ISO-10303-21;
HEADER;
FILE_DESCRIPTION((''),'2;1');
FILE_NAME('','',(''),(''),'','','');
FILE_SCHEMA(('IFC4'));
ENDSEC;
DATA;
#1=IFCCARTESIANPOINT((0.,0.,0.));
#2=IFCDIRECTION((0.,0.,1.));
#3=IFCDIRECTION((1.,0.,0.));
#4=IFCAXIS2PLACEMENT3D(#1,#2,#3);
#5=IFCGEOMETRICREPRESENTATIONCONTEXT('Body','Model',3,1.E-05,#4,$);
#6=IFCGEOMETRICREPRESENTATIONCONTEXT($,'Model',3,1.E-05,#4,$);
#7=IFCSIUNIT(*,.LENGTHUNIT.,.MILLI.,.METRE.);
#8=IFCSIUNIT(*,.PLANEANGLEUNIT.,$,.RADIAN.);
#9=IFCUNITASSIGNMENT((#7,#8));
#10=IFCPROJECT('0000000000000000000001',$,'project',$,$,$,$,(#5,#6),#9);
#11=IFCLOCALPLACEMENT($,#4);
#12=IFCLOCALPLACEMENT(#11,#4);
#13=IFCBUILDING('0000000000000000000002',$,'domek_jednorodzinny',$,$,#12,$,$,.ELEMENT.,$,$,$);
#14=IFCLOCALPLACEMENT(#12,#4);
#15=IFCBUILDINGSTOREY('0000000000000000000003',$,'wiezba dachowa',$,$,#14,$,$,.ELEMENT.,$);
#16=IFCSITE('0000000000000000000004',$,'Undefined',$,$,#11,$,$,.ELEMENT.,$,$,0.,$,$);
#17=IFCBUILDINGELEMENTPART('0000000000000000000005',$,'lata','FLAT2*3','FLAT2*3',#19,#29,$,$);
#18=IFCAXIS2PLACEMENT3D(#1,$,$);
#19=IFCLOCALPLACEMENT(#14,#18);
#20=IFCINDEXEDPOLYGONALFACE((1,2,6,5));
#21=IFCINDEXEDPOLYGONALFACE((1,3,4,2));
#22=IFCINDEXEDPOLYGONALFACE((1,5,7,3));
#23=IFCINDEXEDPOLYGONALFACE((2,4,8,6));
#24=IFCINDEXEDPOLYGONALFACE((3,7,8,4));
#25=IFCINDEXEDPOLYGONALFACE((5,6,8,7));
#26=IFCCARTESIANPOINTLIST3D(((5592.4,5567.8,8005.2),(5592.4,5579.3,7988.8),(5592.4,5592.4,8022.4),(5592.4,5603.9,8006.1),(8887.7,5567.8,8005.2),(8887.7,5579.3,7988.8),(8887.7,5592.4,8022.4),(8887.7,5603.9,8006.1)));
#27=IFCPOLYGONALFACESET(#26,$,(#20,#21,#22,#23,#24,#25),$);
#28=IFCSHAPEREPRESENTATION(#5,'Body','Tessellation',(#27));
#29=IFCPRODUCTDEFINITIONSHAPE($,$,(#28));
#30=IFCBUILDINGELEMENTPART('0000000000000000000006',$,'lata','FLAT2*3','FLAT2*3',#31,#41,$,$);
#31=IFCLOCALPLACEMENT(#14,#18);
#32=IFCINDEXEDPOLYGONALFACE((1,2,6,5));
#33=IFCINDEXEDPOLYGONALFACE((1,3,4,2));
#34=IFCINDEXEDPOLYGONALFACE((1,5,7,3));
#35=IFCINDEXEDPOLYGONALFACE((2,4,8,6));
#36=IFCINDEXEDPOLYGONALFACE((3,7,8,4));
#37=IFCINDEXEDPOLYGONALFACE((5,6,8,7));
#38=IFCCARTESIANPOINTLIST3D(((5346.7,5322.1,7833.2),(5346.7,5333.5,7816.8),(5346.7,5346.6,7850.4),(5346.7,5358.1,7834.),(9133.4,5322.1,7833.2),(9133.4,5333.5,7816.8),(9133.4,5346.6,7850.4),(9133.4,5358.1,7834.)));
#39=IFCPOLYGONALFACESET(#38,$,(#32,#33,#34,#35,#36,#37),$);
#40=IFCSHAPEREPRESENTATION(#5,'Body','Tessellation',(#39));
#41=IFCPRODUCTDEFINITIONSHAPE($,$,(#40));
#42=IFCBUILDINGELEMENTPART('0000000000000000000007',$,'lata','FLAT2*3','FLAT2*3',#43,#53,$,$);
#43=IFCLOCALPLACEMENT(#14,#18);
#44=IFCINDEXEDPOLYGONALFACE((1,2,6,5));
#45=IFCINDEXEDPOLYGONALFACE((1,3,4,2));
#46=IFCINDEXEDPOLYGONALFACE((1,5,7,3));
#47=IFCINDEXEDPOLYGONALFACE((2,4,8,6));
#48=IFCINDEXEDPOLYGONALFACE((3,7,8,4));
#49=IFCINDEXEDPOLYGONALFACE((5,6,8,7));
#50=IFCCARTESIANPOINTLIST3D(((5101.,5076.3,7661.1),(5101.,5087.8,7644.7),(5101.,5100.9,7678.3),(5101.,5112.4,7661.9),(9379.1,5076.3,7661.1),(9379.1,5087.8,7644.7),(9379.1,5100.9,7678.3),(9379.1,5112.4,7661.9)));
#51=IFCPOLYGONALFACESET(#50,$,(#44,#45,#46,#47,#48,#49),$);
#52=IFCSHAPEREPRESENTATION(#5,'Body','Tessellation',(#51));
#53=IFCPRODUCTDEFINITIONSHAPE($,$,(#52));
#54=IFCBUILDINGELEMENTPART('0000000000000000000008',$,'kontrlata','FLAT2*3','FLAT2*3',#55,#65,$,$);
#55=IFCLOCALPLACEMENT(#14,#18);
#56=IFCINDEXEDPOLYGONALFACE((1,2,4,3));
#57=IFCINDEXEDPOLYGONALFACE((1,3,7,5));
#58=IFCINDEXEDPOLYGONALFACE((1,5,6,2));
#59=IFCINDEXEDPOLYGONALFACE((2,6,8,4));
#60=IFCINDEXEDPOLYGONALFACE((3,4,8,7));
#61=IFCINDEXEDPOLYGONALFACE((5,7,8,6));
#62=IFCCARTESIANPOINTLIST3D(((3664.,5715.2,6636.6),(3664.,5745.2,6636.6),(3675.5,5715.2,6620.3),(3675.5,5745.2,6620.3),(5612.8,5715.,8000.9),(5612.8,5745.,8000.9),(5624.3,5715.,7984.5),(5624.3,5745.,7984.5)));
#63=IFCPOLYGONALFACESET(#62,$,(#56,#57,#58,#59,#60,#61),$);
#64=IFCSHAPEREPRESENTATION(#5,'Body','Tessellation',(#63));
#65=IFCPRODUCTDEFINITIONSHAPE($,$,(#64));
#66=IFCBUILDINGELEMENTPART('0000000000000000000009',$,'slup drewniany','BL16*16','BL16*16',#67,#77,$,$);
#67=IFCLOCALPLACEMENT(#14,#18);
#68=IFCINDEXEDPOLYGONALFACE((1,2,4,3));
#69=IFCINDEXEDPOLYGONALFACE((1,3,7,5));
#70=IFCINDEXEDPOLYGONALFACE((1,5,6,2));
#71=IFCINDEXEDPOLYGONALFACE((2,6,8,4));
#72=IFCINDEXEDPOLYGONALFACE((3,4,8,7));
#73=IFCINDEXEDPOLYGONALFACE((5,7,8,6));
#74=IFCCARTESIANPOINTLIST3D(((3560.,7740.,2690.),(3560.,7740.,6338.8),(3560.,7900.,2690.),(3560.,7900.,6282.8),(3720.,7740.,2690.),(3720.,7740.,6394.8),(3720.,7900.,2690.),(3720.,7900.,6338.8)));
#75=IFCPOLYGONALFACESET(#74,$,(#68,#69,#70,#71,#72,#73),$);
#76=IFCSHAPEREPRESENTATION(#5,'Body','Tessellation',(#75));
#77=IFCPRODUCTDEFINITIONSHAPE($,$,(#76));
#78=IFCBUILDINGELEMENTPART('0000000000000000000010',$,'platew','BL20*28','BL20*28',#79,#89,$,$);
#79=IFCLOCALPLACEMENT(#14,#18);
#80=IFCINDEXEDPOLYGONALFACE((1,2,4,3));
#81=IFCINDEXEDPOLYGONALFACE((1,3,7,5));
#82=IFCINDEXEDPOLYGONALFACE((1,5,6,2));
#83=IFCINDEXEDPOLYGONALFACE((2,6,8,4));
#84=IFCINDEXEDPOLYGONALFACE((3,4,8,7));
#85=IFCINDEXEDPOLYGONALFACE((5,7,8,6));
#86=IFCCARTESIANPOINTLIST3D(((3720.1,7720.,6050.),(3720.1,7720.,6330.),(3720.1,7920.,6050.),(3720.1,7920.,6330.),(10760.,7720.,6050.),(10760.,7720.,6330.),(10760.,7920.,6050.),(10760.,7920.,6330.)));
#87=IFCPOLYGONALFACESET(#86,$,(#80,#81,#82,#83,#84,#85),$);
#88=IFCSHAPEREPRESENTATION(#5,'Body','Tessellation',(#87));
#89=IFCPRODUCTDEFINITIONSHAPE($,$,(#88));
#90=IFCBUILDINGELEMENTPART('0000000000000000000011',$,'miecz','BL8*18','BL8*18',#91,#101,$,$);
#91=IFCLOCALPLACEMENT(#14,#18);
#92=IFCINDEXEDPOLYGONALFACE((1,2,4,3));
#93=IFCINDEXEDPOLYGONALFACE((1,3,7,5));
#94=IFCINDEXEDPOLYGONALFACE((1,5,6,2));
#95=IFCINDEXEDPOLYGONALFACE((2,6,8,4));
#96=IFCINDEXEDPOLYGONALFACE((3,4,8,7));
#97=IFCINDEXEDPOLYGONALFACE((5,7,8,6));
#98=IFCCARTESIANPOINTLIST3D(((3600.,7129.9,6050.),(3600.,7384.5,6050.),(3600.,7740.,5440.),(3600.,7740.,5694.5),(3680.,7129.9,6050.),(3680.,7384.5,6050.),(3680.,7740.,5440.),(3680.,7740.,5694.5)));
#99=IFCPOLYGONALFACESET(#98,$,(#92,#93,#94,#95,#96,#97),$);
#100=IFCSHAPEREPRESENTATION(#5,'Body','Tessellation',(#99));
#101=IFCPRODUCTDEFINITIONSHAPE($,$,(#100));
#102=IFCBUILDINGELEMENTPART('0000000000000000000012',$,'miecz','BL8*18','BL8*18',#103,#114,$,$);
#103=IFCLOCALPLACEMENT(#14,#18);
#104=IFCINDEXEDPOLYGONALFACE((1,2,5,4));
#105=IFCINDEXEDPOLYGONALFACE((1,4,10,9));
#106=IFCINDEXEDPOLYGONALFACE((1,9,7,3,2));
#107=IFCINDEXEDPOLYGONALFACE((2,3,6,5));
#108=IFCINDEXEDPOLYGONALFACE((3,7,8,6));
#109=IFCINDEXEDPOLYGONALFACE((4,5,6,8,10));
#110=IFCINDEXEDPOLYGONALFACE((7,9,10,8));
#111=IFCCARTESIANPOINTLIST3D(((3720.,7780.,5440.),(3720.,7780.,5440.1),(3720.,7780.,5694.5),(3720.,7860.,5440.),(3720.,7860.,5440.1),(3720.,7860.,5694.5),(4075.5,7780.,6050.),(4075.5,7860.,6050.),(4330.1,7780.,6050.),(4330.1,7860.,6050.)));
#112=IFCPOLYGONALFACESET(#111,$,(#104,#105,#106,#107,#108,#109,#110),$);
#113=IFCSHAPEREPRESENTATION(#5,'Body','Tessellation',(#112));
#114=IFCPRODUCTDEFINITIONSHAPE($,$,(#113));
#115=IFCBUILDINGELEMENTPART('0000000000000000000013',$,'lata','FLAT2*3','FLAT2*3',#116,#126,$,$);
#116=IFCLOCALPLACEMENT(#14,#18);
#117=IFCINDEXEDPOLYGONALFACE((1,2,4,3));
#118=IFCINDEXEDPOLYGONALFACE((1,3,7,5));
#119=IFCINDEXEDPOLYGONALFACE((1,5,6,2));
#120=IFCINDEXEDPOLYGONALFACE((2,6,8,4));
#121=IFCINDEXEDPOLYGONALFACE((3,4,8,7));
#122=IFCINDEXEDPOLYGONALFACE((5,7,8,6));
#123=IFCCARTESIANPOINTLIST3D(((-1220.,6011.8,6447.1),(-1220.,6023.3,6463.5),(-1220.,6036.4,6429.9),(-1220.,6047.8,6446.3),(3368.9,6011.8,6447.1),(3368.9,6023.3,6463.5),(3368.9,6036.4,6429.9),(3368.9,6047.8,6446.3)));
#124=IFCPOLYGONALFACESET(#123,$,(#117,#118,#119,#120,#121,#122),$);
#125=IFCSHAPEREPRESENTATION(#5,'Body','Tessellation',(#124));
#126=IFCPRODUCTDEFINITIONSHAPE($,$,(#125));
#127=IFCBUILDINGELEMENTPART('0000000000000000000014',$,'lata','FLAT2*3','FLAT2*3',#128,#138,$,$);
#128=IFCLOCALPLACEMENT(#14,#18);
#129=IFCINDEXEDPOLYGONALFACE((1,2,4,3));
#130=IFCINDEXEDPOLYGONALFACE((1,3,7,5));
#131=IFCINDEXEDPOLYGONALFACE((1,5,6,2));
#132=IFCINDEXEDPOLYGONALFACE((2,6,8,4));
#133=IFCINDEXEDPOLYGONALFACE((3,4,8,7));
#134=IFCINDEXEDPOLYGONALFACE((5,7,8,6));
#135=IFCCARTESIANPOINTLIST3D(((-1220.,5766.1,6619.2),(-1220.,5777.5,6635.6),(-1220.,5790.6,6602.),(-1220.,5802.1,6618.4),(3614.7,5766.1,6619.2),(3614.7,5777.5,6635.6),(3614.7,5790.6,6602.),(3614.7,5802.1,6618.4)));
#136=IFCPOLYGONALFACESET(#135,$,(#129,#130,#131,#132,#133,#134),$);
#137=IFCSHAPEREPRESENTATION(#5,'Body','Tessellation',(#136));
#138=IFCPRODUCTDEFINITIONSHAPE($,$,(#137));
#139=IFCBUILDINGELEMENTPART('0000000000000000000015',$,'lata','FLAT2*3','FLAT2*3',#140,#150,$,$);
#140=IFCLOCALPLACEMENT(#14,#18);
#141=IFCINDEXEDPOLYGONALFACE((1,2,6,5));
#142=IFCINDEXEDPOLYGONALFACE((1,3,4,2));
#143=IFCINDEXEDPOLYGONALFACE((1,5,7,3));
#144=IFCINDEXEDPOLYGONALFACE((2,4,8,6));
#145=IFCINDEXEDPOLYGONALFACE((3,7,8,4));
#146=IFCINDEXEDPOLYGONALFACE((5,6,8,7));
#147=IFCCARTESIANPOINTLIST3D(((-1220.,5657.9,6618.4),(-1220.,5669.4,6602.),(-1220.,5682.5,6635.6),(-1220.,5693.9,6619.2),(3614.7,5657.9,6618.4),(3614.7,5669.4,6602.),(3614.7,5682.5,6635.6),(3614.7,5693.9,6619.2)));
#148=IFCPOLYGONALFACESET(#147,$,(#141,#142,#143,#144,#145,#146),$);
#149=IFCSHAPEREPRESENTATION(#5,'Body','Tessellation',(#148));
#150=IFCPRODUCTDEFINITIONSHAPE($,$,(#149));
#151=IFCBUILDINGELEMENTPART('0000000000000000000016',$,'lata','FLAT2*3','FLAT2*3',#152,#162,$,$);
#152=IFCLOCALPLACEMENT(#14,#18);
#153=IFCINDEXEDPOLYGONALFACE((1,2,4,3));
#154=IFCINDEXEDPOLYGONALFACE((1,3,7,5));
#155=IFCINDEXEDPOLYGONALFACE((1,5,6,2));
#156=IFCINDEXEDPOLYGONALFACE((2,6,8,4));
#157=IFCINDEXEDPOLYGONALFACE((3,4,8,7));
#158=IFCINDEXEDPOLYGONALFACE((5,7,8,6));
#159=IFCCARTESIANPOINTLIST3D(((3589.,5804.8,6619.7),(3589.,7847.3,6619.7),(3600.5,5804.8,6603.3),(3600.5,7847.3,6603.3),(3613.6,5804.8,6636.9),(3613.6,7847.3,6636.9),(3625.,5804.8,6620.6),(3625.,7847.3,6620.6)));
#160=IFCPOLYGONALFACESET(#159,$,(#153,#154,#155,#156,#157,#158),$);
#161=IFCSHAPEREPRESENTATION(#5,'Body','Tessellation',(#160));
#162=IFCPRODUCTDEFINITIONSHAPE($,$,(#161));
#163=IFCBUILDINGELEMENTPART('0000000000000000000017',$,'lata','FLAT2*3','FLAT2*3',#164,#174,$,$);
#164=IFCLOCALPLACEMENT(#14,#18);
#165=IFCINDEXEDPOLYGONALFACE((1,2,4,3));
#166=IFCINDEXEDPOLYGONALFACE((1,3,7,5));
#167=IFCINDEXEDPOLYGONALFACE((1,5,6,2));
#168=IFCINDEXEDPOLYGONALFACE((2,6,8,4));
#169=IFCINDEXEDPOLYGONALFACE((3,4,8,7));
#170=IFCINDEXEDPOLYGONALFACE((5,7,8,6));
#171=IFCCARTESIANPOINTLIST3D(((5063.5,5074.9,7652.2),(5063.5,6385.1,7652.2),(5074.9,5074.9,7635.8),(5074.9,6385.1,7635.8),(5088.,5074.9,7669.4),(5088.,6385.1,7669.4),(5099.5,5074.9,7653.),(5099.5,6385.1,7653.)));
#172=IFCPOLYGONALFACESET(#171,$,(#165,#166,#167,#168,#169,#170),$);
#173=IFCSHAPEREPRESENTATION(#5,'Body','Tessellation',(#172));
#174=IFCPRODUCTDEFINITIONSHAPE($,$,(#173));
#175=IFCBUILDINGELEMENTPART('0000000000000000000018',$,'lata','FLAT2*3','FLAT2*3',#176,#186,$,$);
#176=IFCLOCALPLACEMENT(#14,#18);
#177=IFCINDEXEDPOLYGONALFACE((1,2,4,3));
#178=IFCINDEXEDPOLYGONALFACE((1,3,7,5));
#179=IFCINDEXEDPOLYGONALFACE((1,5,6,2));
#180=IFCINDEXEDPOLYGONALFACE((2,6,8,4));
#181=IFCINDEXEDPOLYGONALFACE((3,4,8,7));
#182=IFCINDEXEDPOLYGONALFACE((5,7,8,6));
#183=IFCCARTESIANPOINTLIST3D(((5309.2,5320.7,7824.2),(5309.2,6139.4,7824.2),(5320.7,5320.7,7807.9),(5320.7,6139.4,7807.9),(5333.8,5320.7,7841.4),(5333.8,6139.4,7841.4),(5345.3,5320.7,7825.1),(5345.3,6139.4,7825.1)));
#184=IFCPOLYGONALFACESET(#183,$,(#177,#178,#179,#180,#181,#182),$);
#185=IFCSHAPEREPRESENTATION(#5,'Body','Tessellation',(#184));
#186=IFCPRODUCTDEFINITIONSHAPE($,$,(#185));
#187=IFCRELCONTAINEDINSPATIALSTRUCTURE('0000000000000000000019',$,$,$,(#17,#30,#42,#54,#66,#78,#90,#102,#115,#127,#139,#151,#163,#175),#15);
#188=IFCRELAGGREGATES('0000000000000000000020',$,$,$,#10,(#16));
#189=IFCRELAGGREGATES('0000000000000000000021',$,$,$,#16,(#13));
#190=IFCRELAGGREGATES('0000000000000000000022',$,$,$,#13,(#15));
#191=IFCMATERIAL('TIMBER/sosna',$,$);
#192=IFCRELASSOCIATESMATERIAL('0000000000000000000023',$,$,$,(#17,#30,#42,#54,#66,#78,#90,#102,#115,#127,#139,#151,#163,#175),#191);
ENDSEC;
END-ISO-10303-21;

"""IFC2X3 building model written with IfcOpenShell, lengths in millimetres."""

from ifc_helpers import new_model, si_unit, frame, origin_with_axes, origin_2d_with_axis, place, context, project, spatial, rectangle, extrude, clip, halfspace, material, element, save


model = new_model("IFC2X3")

# Units and contexts
model_context_1 = context("Model", 3, precision=1e-05, world=origin_with_axes(), identifier="Body")
model_context_2 = context("Model", 3, precision=1e-05, world=origin_with_axes())
ifc_project = project(units=[si_unit("LENGTHUNIT", "METRE", prefix="MILLI"), si_unit("PLANEANGLEUNIT", "RADIAN")], contexts=[model_context_1, model_context_2])

# Site, building, storey
site_placement = place(None, origin_with_axes())
site = spatial("IfcSite", under=ifc_project, at=site_placement, Name="Undefined", CompositionType="ELEMENT", RefElevation=0.0)
building_placement = place(site_placement, origin_with_axes())
building = spatial("IfcBuilding", under=site, at=building_placement, Name="domek_jednorodzinny", CompositionType="ELEMENT")
storey_placement = place(building_placement, origin_with_axes())
storey = spatial("IfcBuildingStorey", under=building, at=storey_placement, Name="wiezba dachowa", CompositionType="ELEMENT")

# Building element parts
ifc_material = material(Name="TIMBER/sosna")
building_element_part_1_placement = place(storey_placement, frame((5592.4, 5585.8, 8005.6), z_axis=(0.0, 0.819154, 0.573574), x_axis=(1.0, 0.0, 0.0)))
element("IfcBuildingElementPart", 1, at=building_element_part_1_placement, inside=storey, material=ifc_material, Name="lata", Description="FLAT2*3", ObjectType="FLAT2*3", context=model_context_1, shape_type="SweptSolid", body=[
    extrude(rectangle(XDim=20.0, YDim=30.0, at=origin_2d_with_axis()), frame((3295.2, 0.0, 0.0), z_axis=(-1.0, 0.0, 0.0), x_axis=(0.0, -1.0, 0.0)), (0.0, 0.0, 1.0), 3295.2),
])
building_element_part_2_placement = place(storey_placement, frame((5346.7, 5340.1, 7833.6), z_axis=(0.0, 0.819154, 0.573574), x_axis=(1.0, 0.0, 0.0)))
element("IfcBuildingElementPart", 2, at=building_element_part_2_placement, inside=storey, material=ifc_material, Name="lata", Description="FLAT2*3", ObjectType="FLAT2*3", context=model_context_1, shape_type="SweptSolid", body=[
    extrude(rectangle(XDim=20.0, YDim=30.0, at=origin_2d_with_axis()), frame((3786.7, 0.0, 0.0), z_axis=(-1.0, 0.0, 0.0), x_axis=(0.0, -1.0, 0.0)), (0.0, 0.0, 1.0), 3786.7),
])
building_element_part_3_placement = place(storey_placement, frame((5101.0, 5094.3, 7661.5), z_axis=(0.0, 0.819154, 0.573574), x_axis=(1.0, 0.0, 0.0)))
element("IfcBuildingElementPart", 3, at=building_element_part_3_placement, inside=storey, material=ifc_material, Name="lata", Description="FLAT2*3", ObjectType="FLAT2*3", context=model_context_1, shape_type="SweptSolid", body=[
    extrude(rectangle(XDim=20.0, YDim=30.0, at=origin_2d_with_axis()), frame((4278.2, 0.0, 0.0), z_axis=(-1.0, 0.0, 0.0), x_axis=(0.0, -1.0, 0.0)), (0.0, 0.0, 1.0), 4278.2),
])
building_element_part_4_placement = place(storey_placement, frame((3669.8, 5730.2, 6628.4), z_axis=(-0.000099, -1.0, -0.000003), x_axis=(0.819202, -0.000083, 0.573505)))
element("IfcBuildingElementPart", 4, at=building_element_part_4_placement, inside=storey, material=ifc_material, Name="kontrlata", Description="FLAT2*3", ObjectType="FLAT2*3", context=model_context_1, shape_type="SweptSolid", body=[
    extrude(rectangle(XDim=20.0, YDim=30.0, at=origin_2d_with_axis()), frame((2378.8, 0.0, 0.0), z_axis=(-1.0, 0.0, 0.0), x_axis=(0.0, -1.0, 0.0)), (0.0, 0.0, 1.0), 2378.8),
])
building_element_part_5_placement = place(storey_placement, frame((3640.0, 7820.0, 2690.0), z_axis=(-1.0, 0.0, 0.0), x_axis=(0.0, 0.0, 1.0)))
element("IfcBuildingElementPart", 5, at=building_element_part_5_placement, inside=storey, material=ifc_material, Name="slup drewniany", Description="BL16*16", ObjectType="BL16*16", context=model_context_1, shape_type="Clipping", body=[
    clip(extrude(rectangle(XDim=160.0, YDim=160.0, at=origin_2d_with_axis()), frame((3730.0, 0.0, 0.0), z_axis=(-1.0, 0.0, 0.0), x_axis=(0.0, -1.0, 0.0)), (0.0, 0.0, 1.0), 3730.0), halfspace(frame((3704.8, -80.0, -80.0), z_axis=(0.89617, 0.313751, 0.313751), x_axis=(-0.330436, 0.0, 0.943828)), False)),
])
building_element_part_6_placement = place(storey_placement, frame((3720.1, 7820.0, 6190.0), z_axis=(0.0, 0.0, 1.0), x_axis=(1.0, 0.0, 0.0)))
element("IfcBuildingElementPart", 6, at=building_element_part_6_placement, inside=storey, material=ifc_material, Name="platew", Description="BL20*28", ObjectType="BL20*28", context=model_context_1, shape_type="SweptSolid", body=[
    extrude(rectangle(XDim=200.0, YDim=280.0, at=origin_2d_with_axis()), frame((7040.0, 0.0, 0.0), z_axis=(-1.0, 0.0, 0.0), x_axis=(0.0, -1.0, 0.0)), (0.0, 0.0, 1.0), 7040.0),
])
building_element_part_7_placement = place(storey_placement, frame((3640.0, 7803.6, 5503.7), z_axis=(0.0, 0.70704, 0.707173), x_axis=(0.0, -0.707173, 0.70704)))
element("IfcBuildingElementPart", 7, at=building_element_part_7_placement, inside=storey, material=ifc_material, Name="miecz", Description="BL8*18", ObjectType="BL8*18", context=model_context_1, shape_type="Clipping", body=[
    clip(clip(extrude(rectangle(XDim=80.0, YDim=180.0, at=origin_2d_with_axis()), frame((862.7, 0.0, 0.0), z_axis=(-1.0, 0.0, 0.0), x_axis=(0.0, -1.0, 0.0)), (0.0, 0.0, 1.0), 862.7), halfspace(frame((862.7, 40.0, -90.0), z_axis=(0.70704, 0.0, 0.707173), x_axis=(0.0, -1.0, 0.0)), False)), halfspace(frame((0.0, -40.0, -90.0), z_axis=(-0.707205, 0.0, 0.707008), x_axis=(0.0, 1.0, 0.0)), False)),
])
building_element_part_8_placement = place(storey_placement, frame((3656.4, 7820.0, 5503.7), z_axis=(-0.70704, 0.0, 0.707173), x_axis=(0.707173, 0.0, 0.70704)))
element("IfcBuildingElementPart", 8, at=building_element_part_8_placement, inside=storey, material=ifc_material, Name="miecz", Description="BL8*18", ObjectType="BL8*18", context=model_context_1, shape_type="Clipping", body=[
    clip(clip(extrude(rectangle(XDim=80.0, YDim=180.0, at=origin_2d_with_axis()), frame((862.7, 0.0, 0.0), z_axis=(-1.0, 0.0, 0.0), x_axis=(0.0, -1.0, 0.0)), (0.0, 0.0, 1.0), 862.7), halfspace(frame((862.7, 40.0, -90.0), z_axis=(0.70704, 0.0, 0.707173), x_axis=(0.0, -1.0, 0.0)), False)), halfspace(frame((0.0, -40.0, -90.0), z_axis=(-0.707138, 0.0, 0.707075), x_axis=(0.0, 1.0, 0.0)), False)),
])
building_element_part_9_placement = place(storey_placement, frame((3368.9, 6029.8, 6446.7), z_axis=(0.0, -0.819154, 0.573574), x_axis=(-1.0, 0.0, 0.0)))
element("IfcBuildingElementPart", 9, at=building_element_part_9_placement, inside=storey, material=ifc_material, Name="lata", Description="FLAT2*3", ObjectType="FLAT2*3", context=model_context_1, shape_type="SweptSolid", body=[
    extrude(rectangle(XDim=20.0, YDim=30.0, at=origin_2d_with_axis()), frame((4588.9, 0.0, 0.0), z_axis=(-1.0, 0.0, 0.0), x_axis=(0.0, -1.0, 0.0)), (0.0, 0.0, 1.0), 4588.9),
])
for number, where, z_axis, x_axis, name in (
    (10, (3614.7, 5784.1, 6618.8), (0.0, -0.819154, 0.573574), (-1.0, 0.0, 0.0), "lata"),
    (11, (3614.7, 5675.9, 6618.8), (0.0, 0.819154, 0.573574), (-1.0, 0.0, 0.0), "lata"),
):
    element("IfcBuildingElementPart", number, at=place(storey_placement, frame(where, z_axis=z_axis, x_axis=x_axis)), inside=storey, material=ifc_material, Name=name, Description="FLAT2*3", ObjectType="FLAT2*3", context=model_context_1, shape_type="SweptSolid", body=[
        extrude(rectangle(XDim=20.0, YDim=30.0, at=origin_2d_with_axis()), frame((4834.6, 0.0, 0.0), z_axis=(-1.0, 0.0, 0.0), x_axis=(0.0, -1.0, 0.0)), (0.0, 0.0, 1.0), 4834.6),
    ])
building_element_part_10_placement = place(storey_placement, frame((3607.0, 7847.3, 6620.1), z_axis=(0.819152, 0.0, 0.573576), x_axis=(0.0, -1.0, 0.0)))
element("IfcBuildingElementPart", 12, at=building_element_part_10_placement, inside=storey, material=ifc_material, Name="lata", Description="FLAT2*3", ObjectType="FLAT2*3", context=model_context_1, shape_type="SweptSolid", body=[
    extrude(rectangle(XDim=20.0, YDim=30.0, at=origin_2d_with_axis()), frame((2042.4, 0.0, 0.0), z_axis=(-1.0, 0.0, 0.0), x_axis=(0.0, -1.0, 0.0)), (0.0, 0.0, 1.0), 2042.4),
])
building_element_part_11_placement = place(storey_placement, frame((5081.5, 5074.9, 7652.6), z_axis=(0.819152, 0.0, 0.573576), x_axis=(0.0, 1.0, 0.0)))
element("IfcBuildingElementPart", 13, at=building_element_part_11_placement, inside=storey, material=ifc_material, Name="lata", Description="FLAT2*3", ObjectType="FLAT2*3", context=model_context_1, shape_type="SweptSolid", body=[
    extrude(rectangle(XDim=20.0, YDim=30.0, at=origin_2d_with_axis()), frame((1310.2, 0.0, 0.0), z_axis=(-1.0, 0.0, 0.0), x_axis=(0.0, -1.0, 0.0)), (0.0, 0.0, 1.0), 1310.2),
])
building_element_part_12_placement = place(storey_placement, frame((5327.2, 5320.7, 7824.7), z_axis=(0.819152, 0.0, 0.573576), x_axis=(0.0, 1.0, 0.0)))
element("IfcBuildingElementPart", 14, at=building_element_part_12_placement, inside=storey, material=ifc_material, Name="lata", Description="FLAT2*3", ObjectType="FLAT2*3", context=model_context_1, shape_type="SweptSolid", body=[
    extrude(rectangle(XDim=20.0, YDim=30.0, at=origin_2d_with_axis()), frame((818.7, 0.0, 0.0), z_axis=(-1.0, 0.0, 0.0), x_axis=(0.0, -1.0, 0.0)), (0.0, 0.0, 1.0), 818.7),
])

save(model, "model.ifc")
